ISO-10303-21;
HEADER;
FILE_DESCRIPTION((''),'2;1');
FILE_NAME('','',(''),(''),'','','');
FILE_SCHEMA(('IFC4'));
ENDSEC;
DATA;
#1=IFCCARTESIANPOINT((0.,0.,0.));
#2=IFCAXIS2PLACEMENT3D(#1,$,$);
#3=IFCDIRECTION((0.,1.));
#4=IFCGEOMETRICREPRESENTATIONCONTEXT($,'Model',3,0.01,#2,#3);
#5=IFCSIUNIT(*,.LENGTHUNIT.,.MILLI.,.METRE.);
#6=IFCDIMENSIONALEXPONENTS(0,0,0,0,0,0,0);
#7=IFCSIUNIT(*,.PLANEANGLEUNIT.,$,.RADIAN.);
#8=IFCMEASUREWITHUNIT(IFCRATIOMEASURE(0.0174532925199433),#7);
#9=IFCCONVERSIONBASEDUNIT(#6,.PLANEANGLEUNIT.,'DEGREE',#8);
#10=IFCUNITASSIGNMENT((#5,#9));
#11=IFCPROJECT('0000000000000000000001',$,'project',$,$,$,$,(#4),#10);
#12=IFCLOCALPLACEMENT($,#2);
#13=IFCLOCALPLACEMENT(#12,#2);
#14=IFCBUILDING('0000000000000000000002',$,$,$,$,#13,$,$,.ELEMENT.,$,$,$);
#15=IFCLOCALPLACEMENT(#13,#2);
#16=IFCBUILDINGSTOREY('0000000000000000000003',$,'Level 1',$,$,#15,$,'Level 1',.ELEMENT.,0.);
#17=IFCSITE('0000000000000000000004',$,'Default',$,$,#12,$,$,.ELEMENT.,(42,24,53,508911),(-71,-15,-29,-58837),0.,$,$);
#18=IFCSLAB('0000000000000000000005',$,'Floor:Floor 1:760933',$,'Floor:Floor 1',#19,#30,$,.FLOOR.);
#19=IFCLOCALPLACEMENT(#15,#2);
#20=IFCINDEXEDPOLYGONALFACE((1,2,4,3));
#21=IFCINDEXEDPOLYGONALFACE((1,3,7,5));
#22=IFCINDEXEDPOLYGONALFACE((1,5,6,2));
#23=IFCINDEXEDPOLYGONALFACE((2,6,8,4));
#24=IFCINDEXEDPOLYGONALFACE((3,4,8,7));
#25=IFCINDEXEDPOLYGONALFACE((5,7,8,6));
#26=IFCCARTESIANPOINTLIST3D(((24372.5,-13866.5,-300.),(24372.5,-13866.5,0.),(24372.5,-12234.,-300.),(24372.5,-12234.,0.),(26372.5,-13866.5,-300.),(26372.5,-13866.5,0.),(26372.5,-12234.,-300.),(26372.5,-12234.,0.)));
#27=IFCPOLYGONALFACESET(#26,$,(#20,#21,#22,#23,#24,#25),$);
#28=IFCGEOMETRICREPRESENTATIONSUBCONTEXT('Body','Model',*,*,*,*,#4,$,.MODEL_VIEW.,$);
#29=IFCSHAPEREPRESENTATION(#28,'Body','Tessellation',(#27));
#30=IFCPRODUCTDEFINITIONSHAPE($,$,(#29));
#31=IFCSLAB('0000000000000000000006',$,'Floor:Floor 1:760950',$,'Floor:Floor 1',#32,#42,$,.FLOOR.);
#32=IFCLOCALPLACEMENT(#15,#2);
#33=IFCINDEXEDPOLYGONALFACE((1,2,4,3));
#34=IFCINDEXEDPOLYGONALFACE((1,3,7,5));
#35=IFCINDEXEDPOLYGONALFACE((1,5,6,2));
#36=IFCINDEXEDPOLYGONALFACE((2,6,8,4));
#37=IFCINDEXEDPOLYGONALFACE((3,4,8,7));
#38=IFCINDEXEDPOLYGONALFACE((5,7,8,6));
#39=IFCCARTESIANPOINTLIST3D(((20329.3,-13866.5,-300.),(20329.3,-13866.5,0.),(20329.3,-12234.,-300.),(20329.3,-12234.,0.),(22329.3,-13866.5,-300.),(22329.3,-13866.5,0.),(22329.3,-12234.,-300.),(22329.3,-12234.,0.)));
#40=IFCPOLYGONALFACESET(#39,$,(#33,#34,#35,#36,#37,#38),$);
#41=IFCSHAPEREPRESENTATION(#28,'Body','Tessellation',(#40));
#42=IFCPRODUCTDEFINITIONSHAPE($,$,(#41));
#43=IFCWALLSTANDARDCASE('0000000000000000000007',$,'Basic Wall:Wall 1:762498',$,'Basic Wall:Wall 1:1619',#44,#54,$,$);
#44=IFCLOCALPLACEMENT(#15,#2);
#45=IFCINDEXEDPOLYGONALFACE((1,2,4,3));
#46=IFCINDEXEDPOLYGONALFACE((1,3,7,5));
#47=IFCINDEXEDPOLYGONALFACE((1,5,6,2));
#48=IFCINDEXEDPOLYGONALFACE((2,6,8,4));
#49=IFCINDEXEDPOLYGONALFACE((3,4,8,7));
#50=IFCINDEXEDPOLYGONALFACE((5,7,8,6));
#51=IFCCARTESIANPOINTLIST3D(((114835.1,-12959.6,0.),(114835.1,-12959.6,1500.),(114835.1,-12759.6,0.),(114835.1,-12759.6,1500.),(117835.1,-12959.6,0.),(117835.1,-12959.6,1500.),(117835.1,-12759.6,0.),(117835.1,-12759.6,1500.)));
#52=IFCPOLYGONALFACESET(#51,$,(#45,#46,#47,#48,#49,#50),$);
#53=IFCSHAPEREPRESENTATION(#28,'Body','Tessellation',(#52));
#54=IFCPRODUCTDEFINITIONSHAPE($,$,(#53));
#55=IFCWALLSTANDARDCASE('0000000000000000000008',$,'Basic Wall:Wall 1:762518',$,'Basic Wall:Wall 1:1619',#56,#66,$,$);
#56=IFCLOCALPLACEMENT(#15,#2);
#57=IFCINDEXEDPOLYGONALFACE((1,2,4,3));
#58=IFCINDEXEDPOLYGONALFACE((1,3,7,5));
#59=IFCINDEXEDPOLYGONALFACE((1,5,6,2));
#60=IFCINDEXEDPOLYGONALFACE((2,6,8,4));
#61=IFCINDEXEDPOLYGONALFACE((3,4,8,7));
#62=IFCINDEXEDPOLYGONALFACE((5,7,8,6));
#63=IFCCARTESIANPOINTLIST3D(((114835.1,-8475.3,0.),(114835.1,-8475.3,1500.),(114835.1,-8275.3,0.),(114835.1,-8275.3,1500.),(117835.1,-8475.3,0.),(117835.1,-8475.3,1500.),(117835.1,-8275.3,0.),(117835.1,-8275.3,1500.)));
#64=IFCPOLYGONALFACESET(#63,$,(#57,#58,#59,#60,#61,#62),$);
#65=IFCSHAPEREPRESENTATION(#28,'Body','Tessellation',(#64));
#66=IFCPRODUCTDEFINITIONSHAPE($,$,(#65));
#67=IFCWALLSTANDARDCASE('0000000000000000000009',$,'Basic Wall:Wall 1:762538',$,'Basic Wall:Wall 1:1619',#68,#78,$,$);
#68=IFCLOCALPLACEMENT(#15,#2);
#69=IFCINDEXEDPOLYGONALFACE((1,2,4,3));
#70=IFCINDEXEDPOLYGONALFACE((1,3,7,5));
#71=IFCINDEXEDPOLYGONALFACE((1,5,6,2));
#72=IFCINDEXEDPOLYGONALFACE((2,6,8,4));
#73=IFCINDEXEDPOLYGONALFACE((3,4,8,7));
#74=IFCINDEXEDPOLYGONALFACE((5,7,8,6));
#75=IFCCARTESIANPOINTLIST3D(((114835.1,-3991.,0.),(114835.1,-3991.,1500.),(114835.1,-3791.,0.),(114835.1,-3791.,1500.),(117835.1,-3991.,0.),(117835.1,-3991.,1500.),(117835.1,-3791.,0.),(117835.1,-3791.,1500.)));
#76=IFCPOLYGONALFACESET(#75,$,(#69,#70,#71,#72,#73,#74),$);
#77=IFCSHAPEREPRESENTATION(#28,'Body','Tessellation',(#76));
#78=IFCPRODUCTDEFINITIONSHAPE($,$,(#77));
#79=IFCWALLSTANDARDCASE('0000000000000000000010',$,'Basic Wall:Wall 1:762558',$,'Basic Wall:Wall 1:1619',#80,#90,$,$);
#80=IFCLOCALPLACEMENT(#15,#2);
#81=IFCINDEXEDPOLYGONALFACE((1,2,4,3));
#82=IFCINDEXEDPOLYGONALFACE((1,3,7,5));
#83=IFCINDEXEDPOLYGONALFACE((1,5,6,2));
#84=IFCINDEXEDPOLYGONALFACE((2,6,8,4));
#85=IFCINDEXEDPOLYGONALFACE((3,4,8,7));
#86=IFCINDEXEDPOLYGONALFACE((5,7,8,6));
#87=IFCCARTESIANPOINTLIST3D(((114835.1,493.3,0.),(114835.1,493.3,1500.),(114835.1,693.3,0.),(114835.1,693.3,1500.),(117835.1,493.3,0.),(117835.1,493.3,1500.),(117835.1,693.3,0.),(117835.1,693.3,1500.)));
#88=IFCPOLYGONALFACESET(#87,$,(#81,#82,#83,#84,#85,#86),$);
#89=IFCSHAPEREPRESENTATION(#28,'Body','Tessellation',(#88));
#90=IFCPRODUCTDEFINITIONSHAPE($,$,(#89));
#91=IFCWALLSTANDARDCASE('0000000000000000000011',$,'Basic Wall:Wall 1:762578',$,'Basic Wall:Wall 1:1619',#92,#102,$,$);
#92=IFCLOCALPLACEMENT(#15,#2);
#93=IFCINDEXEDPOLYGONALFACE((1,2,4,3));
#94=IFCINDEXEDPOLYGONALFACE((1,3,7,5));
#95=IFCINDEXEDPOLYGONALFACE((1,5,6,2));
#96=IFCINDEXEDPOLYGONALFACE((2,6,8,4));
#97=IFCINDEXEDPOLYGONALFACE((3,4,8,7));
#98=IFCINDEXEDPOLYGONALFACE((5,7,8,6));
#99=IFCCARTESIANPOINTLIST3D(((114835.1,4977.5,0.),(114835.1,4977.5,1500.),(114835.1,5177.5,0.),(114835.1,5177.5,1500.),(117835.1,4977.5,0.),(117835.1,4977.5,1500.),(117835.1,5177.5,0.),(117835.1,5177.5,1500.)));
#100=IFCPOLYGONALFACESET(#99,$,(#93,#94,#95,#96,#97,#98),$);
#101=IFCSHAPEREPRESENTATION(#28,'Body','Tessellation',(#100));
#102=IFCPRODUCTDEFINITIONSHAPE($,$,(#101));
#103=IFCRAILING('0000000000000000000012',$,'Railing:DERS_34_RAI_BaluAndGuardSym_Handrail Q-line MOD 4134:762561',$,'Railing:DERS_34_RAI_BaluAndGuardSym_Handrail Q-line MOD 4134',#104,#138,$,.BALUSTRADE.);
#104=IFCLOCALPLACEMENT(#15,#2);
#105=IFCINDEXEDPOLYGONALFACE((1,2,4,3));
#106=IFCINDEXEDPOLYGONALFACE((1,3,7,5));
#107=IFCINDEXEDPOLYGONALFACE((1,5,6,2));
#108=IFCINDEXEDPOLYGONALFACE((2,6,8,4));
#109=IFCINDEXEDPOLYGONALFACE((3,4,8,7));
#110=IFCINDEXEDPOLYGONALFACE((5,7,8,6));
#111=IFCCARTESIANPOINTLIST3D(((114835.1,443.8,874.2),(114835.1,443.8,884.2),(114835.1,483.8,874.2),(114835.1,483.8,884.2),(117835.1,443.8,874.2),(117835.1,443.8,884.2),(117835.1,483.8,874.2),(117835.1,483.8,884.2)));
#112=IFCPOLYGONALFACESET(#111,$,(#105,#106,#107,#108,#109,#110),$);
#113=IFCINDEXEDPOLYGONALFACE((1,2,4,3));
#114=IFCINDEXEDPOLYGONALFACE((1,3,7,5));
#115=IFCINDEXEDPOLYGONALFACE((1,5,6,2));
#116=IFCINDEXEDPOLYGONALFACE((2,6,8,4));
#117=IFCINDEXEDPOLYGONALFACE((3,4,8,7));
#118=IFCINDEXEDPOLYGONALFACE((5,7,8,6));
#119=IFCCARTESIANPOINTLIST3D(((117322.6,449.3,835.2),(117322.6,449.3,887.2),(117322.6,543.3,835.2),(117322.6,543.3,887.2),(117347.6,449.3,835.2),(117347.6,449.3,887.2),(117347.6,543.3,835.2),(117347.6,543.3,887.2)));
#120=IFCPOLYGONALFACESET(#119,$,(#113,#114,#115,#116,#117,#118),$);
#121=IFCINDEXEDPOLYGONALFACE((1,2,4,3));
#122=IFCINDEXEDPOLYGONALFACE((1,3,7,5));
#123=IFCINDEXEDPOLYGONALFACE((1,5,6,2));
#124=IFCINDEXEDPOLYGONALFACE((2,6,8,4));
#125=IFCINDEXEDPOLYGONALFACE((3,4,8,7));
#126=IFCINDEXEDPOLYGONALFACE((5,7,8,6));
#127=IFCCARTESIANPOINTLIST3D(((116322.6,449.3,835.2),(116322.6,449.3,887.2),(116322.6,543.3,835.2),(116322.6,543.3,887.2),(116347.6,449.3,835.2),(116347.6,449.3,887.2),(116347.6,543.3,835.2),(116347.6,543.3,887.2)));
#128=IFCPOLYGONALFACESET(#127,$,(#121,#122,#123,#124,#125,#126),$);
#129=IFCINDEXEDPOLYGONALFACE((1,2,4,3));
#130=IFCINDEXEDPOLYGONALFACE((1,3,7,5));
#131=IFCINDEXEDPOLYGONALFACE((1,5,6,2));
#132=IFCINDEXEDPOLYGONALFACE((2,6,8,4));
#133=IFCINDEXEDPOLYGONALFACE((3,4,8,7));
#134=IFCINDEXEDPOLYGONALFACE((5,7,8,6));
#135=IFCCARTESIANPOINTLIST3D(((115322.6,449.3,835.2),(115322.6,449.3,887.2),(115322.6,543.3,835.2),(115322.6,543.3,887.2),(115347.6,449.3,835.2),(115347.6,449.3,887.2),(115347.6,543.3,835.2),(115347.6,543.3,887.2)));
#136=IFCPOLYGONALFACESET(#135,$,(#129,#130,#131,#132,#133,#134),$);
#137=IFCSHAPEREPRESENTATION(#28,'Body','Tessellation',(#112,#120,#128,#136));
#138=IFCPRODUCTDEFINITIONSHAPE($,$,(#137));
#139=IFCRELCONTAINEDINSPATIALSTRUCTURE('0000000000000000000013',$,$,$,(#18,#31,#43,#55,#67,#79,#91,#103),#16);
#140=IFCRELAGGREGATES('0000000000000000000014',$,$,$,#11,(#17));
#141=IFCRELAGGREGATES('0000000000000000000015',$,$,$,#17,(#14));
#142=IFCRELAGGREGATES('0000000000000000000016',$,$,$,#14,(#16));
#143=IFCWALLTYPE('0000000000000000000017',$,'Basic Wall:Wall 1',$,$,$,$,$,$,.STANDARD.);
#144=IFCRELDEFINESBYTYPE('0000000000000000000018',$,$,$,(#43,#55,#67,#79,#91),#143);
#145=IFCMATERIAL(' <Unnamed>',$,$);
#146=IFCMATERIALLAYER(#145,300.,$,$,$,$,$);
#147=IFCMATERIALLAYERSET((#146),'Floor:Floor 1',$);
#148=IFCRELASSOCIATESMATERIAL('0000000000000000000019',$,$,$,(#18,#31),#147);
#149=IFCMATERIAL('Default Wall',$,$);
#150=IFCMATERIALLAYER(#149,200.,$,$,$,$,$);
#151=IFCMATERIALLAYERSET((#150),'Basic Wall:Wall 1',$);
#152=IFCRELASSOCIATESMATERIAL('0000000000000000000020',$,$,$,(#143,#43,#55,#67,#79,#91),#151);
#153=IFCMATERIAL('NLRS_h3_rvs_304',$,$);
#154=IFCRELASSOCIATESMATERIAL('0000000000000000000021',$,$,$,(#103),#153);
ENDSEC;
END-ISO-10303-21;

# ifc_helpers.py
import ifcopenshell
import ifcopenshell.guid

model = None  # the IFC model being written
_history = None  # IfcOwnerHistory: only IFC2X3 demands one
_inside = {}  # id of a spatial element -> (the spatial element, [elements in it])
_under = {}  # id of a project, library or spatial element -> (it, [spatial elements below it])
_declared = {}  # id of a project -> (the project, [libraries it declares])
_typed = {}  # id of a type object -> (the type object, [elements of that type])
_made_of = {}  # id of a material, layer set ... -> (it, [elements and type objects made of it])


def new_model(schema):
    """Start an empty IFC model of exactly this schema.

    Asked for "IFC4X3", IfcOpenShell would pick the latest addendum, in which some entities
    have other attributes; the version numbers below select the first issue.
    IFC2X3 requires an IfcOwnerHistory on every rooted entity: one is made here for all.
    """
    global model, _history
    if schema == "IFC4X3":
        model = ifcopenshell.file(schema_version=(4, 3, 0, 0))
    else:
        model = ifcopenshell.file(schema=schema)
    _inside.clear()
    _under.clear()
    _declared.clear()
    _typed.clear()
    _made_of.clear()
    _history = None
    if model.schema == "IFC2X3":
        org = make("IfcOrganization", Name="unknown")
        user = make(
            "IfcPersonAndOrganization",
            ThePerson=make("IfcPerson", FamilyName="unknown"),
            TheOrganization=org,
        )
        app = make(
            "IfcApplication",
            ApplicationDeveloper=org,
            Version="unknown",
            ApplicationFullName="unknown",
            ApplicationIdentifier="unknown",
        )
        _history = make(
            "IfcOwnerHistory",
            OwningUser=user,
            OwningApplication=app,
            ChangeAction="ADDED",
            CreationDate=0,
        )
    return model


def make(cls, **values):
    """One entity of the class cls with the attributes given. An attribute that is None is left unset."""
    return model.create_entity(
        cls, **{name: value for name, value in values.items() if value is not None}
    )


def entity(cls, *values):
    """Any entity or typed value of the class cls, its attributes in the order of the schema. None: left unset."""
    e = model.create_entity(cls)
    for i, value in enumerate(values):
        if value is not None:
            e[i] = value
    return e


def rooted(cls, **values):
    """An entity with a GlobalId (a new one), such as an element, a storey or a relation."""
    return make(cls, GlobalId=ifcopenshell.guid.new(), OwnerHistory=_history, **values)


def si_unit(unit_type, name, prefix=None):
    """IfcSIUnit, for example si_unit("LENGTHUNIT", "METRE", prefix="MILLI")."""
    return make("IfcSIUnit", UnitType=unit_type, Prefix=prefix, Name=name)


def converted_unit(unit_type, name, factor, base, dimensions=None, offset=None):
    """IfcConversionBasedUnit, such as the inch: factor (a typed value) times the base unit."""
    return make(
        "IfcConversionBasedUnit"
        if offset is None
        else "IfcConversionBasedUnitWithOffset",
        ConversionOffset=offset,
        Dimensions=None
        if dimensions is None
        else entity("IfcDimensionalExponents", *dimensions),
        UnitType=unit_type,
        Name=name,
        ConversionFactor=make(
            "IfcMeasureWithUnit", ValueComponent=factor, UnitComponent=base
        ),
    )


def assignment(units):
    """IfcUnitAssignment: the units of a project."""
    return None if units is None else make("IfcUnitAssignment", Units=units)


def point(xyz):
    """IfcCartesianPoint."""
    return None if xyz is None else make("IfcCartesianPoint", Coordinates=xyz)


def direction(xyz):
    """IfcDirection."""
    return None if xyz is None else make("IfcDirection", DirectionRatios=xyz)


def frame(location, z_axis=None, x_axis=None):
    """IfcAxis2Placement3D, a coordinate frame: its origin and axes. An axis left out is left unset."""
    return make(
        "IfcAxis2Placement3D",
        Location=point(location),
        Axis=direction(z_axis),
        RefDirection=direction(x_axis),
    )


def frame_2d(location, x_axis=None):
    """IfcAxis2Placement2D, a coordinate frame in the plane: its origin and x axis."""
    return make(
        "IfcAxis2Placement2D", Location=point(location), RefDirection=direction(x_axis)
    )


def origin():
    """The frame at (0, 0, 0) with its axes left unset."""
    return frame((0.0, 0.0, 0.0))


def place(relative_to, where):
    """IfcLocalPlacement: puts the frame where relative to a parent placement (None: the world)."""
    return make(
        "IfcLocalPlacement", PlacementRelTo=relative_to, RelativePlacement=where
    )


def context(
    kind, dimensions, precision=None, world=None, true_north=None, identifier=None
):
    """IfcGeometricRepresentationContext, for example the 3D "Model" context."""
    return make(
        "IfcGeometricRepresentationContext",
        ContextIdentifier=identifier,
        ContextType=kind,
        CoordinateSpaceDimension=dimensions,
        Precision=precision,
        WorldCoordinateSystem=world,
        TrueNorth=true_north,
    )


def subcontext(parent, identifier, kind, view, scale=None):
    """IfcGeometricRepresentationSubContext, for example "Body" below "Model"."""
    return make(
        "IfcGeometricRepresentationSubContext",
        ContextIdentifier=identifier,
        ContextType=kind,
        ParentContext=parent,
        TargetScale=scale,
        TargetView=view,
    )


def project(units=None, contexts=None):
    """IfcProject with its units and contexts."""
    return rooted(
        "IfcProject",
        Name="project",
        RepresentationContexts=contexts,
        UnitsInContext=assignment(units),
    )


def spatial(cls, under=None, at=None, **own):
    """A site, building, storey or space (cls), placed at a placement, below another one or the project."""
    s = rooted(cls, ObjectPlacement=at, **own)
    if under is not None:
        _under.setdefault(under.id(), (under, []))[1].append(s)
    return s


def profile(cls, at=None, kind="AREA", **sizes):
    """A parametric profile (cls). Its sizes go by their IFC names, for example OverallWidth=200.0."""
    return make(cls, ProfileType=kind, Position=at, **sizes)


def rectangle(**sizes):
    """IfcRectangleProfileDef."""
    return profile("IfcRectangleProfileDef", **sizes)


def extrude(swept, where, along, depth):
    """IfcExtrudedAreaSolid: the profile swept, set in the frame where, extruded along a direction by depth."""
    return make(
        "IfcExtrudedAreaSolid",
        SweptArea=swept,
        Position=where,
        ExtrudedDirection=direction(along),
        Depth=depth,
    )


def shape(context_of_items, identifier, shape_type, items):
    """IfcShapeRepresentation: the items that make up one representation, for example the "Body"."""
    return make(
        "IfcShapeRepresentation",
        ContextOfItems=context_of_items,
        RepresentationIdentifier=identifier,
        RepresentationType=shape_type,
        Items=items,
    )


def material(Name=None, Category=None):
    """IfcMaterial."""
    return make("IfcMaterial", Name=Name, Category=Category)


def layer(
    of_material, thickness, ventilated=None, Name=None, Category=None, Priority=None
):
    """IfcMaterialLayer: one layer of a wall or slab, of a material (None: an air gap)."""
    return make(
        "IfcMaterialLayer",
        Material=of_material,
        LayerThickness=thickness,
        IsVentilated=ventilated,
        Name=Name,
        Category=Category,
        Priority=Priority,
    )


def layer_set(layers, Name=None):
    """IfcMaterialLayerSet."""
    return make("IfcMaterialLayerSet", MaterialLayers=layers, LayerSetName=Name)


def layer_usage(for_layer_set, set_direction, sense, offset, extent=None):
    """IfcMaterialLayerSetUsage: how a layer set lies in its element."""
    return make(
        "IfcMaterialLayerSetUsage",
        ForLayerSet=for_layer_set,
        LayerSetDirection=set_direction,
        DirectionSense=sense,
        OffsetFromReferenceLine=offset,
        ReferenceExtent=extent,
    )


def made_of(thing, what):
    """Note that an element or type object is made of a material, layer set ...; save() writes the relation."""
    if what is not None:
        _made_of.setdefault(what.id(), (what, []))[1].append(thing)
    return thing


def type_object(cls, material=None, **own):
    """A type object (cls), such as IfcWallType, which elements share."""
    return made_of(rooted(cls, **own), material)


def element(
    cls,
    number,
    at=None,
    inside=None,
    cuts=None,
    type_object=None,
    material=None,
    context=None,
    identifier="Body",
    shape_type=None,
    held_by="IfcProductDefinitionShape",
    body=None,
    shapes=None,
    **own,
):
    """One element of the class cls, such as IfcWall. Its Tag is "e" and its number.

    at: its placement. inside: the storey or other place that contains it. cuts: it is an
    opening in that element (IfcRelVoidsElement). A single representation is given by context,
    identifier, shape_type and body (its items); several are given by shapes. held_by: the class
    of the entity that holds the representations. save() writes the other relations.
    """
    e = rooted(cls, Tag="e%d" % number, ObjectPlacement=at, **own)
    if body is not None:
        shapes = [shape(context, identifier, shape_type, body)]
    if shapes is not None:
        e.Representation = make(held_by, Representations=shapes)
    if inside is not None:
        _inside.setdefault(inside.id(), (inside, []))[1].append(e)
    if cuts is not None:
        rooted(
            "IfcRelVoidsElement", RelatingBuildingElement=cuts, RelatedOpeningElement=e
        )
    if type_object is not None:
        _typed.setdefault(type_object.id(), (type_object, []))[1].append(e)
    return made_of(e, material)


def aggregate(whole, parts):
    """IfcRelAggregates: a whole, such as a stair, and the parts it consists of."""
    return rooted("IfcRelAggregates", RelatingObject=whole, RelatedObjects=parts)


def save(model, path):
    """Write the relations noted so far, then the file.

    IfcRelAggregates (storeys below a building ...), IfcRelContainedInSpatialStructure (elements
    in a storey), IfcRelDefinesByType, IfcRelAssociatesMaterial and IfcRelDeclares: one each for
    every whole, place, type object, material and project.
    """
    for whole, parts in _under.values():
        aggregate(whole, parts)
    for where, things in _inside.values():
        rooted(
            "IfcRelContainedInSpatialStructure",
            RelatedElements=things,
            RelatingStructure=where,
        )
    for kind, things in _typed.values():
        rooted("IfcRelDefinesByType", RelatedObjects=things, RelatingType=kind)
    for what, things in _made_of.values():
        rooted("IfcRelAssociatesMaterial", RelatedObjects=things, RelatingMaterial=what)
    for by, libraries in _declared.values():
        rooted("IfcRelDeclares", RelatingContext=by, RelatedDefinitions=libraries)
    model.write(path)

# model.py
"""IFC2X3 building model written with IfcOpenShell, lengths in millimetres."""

from ifc_helpers import new_model, entity, si_unit, converted_unit, direction, frame, frame_2d, origin, place, context, subcontext, project, spatial, rectangle, extrude, material, layer, layer_set, layer_usage, type_object, element, save


model = new_model("IFC2X3")

# Units and contexts
model_context = context("Model", 3, precision=0.01, world=origin(), true_north=direction((0.0, 1.0)))
body_context = subcontext(model_context, "Body", "Model", "MODEL_VIEW")
ifc_project = project(units=[si_unit("LENGTHUNIT", "METRE", prefix="MILLI"), converted_unit("PLANEANGLEUNIT", "DEGREE", entity("IfcRatioMeasure", 0.0174532925199433), si_unit("PLANEANGLEUNIT", "RADIAN"), dimensions=[0, 0, 0, 0, 0, 0, 0])], contexts=[model_context])

# Site, building, storey
site_placement = place(None, origin())
site = spatial("IfcSite", under=ifc_project, at=site_placement, Name="Default", CompositionType="ELEMENT", RefLatitude=(42, 24, 53, 508911), RefLongitude=(-71, -15, -29, -58837), RefElevation=0.0)
building_placement = place(site_placement, origin())
building = spatial("IfcBuilding", under=site, at=building_placement, CompositionType="ELEMENT")
storey_placement = place(building_placement, origin())
storey = spatial("IfcBuildingStorey", under=building, at=storey_placement, Name="Level 1", LongName="Level 1", CompositionType="ELEMENT", Elevation=0.0)

# Slabs
ifc_material_1 = material(Name=" <Unnamed>")
ifc_layer_1 = layer(ifc_material_1, 300.0)
ifc_layer_set_1 = layer_set([ifc_layer_1], Name="Floor:Floor 1")
ifc_layer_usage_1 = layer_usage(ifc_layer_set_1, "AXIS3", "POSITIVE", 0.0)
slab_1_placement = place(storey_placement, origin())
element("IfcSlab", 1, at=slab_1_placement, inside=storey, material=ifc_layer_usage_1, Name="Floor:Floor 1:760933", ObjectType="Floor:Floor 1", PredefinedType="FLOOR", context=body_context, shape_type="SweptSolid", body=[
    extrude(rectangle(XDim=1632.5, YDim=2000.0, at=frame_2d((0.0, 0.0), x_axis=(1.0, 0.0))), frame((25372.5, -13050.3, 0.0), z_axis=(0.0, 0.0, -1.0), x_axis=(0.0, 1.0, 0.0)), (0.0, 0.0, 1.0), 300.0),
])
ifc_layer_usage_2 = layer_usage(ifc_layer_set_1, "AXIS3", "POSITIVE", 0.0)
slab_2_placement = place(storey_placement, origin())
element("IfcSlab", 2, at=slab_2_placement, inside=storey, material=ifc_layer_usage_2, Name="Floor:Floor 1:760950", ObjectType="Floor:Floor 1", PredefinedType="FLOOR", context=body_context, shape_type="SweptSolid", body=[
    extrude(rectangle(XDim=1632.5, YDim=2000.0, at=frame_2d((0.0, 0.0), x_axis=(1.0, 0.0))), frame((21329.3, -13050.3, 0.0), z_axis=(0.0, 0.0, -1.0), x_axis=(0.0, 1.0, 0.0)), (0.0, 0.0, 1.0), 300.0),
])

# Walls
ifc_material_2 = material(Name="Default Wall")
ifc_layer_2 = layer(ifc_material_2, 200.0)
ifc_layer_set_2 = layer_set([ifc_layer_2], Name="Basic Wall:Wall 1")
ifc_layer_usage_3 = layer_usage(ifc_layer_set_2, "AXIS2", "NEGATIVE", 100.0)
wall_type = type_object("IfcWallType", Name="Basic Wall:Wall 1", PredefinedType="STANDARD", material=ifc_layer_set_2)
wall_1_placement = place(storey_placement, frame((114835.1, -12859.6, 0.0)))
element("IfcWallStandardCase", 3, at=wall_1_placement, inside=storey, type_object=wall_type, material=ifc_layer_usage_3, Name="Basic Wall:Wall 1:762498", ObjectType="Basic Wall:Wall 1:1619", context=body_context, shape_type="SweptSolid", body=[
    extrude(rectangle(XDim=3000.0, YDim=200.0, at=frame_2d((1500.0, 0.0), x_axis=(-1.0, 0.0))), origin(), (0.0, 0.0, 1.0), 1500.0),
])
ifc_layer_usage_4 = layer_usage(ifc_layer_set_2, "AXIS2", "NEGATIVE", 100.0)
wall_2_placement = place(storey_placement, frame((114835.1, -8375.3, 0.0)))
element("IfcWallStandardCase", 4, at=wall_2_placement, inside=storey, type_object=wall_type, material=ifc_layer_usage_4, Name="Basic Wall:Wall 1:762518", ObjectType="Basic Wall:Wall 1:1619", context=body_context, shape_type="SweptSolid", body=[
    extrude(rectangle(XDim=3000.0, YDim=200.0, at=frame_2d((1500.0, 0.0), x_axis=(-1.0, 0.0))), origin(), (0.0, 0.0, 1.0), 1500.0),
])
ifc_layer_usage_5 = layer_usage(ifc_layer_set_2, "AXIS2", "NEGATIVE", 100.0)
wall_3_placement = place(storey_placement, frame((114835.1, -3891.0, 0.0)))
element("IfcWallStandardCase", 5, at=wall_3_placement, inside=storey, type_object=wall_type, material=ifc_layer_usage_5, Name="Basic Wall:Wall 1:762538", ObjectType="Basic Wall:Wall 1:1619", context=body_context, shape_type="SweptSolid", body=[
    extrude(rectangle(XDim=3000.0, YDim=200.0, at=frame_2d((1500.0, 0.0), x_axis=(-1.0, 0.0))), origin(), (0.0, 0.0, 1.0), 1500.0),
])
ifc_layer_usage_6 = layer_usage(ifc_layer_set_2, "AXIS2", "NEGATIVE", 100.0)
wall_4_placement = place(storey_placement, frame((114835.1, 593.3, 0.0)))
element("IfcWallStandardCase", 6, at=wall_4_placement, inside=storey, type_object=wall_type, material=ifc_layer_usage_6, Name="Basic Wall:Wall 1:762558", ObjectType="Basic Wall:Wall 1:1619", context=body_context, shape_type="SweptSolid", body=[
    extrude(rectangle(XDim=3000.0, YDim=200.0, at=frame_2d((1500.0, 0.0), x_axis=(-1.0, 0.0))), origin(), (0.0, 0.0, 1.0), 1500.0),
])
ifc_layer_usage_7 = layer_usage(ifc_layer_set_2, "AXIS2", "NEGATIVE", 100.0)
wall_5_placement = place(storey_placement, frame((114835.1, 5077.5, 0.0)))
element("IfcWallStandardCase", 7, at=wall_5_placement, inside=storey, type_object=wall_type, material=ifc_layer_usage_7, Name="Basic Wall:Wall 1:762578", ObjectType="Basic Wall:Wall 1:1619", context=body_context, shape_type="SweptSolid", body=[
    extrude(rectangle(XDim=3000.0, YDim=200.0, at=frame_2d((1500.0, 0.0), x_axis=(-1.0, 0.0))), origin(), (0.0, 0.0, 1.0), 1500.0),
])

# Railing
ifc_material_3 = material(Name="NLRS_h3_rvs_304")
railing_1_placement = place(storey_placement, origin())
element("IfcRailing", 8, at=railing_1_placement, inside=storey, material=ifc_material_3, Name="Railing:DERS_34_RAI_BaluAndGuardSym_Handrail Q-line MOD 4134:762561", ObjectType="Railing:DERS_34_RAI_BaluAndGuardSym_Handrail Q-line MOD 4134", PredefinedType="BALUSTRADE", context=body_context, shape_type="SweptSolid", body=[
    extrude(rectangle(XDim=3000.0, YDim=40.0, at=frame_2d((0.0, 0.0), x_axis=(1.0, 0.0))), frame((116335.1, 463.8, 874.2), z_axis=(0.0, 0.0, 1.0), x_axis=(-1.0, 0.0, 0.0)), (0.0, 0.0, 1.0), 10.0),
    extrude(rectangle(XDim=94.0, YDim=25.0, at=frame_2d((0.0, 0.0), x_axis=(1.0, 0.0))), frame((117335.1, 496.3, 835.2), z_axis=(0.0, 0.0, 1.0), x_axis=(0.0, 1.0, 0.0)), (0.0, 0.0, 1.0), 52.0),
    extrude(rectangle(XDim=94.0, YDim=25.0, at=frame_2d((0.0, 0.0), x_axis=(1.0, 0.0))), frame((116335.1, 496.3, 835.2), z_axis=(0.0, 0.0, 1.0), x_axis=(0.0, 1.0, 0.0)), (0.0, 0.0, 1.0), 52.0),
    extrude(rectangle(XDim=94.0, YDim=25.0, at=frame_2d((0.0, 0.0), x_axis=(1.0, 0.0))), frame((115335.1, 496.3, 835.2), z_axis=(0.0, 0.0, 1.0), x_axis=(0.0, 1.0, 0.0)), (0.0, 0.0, 1.0), 52.0),
])

save(model, "model.ifc")
